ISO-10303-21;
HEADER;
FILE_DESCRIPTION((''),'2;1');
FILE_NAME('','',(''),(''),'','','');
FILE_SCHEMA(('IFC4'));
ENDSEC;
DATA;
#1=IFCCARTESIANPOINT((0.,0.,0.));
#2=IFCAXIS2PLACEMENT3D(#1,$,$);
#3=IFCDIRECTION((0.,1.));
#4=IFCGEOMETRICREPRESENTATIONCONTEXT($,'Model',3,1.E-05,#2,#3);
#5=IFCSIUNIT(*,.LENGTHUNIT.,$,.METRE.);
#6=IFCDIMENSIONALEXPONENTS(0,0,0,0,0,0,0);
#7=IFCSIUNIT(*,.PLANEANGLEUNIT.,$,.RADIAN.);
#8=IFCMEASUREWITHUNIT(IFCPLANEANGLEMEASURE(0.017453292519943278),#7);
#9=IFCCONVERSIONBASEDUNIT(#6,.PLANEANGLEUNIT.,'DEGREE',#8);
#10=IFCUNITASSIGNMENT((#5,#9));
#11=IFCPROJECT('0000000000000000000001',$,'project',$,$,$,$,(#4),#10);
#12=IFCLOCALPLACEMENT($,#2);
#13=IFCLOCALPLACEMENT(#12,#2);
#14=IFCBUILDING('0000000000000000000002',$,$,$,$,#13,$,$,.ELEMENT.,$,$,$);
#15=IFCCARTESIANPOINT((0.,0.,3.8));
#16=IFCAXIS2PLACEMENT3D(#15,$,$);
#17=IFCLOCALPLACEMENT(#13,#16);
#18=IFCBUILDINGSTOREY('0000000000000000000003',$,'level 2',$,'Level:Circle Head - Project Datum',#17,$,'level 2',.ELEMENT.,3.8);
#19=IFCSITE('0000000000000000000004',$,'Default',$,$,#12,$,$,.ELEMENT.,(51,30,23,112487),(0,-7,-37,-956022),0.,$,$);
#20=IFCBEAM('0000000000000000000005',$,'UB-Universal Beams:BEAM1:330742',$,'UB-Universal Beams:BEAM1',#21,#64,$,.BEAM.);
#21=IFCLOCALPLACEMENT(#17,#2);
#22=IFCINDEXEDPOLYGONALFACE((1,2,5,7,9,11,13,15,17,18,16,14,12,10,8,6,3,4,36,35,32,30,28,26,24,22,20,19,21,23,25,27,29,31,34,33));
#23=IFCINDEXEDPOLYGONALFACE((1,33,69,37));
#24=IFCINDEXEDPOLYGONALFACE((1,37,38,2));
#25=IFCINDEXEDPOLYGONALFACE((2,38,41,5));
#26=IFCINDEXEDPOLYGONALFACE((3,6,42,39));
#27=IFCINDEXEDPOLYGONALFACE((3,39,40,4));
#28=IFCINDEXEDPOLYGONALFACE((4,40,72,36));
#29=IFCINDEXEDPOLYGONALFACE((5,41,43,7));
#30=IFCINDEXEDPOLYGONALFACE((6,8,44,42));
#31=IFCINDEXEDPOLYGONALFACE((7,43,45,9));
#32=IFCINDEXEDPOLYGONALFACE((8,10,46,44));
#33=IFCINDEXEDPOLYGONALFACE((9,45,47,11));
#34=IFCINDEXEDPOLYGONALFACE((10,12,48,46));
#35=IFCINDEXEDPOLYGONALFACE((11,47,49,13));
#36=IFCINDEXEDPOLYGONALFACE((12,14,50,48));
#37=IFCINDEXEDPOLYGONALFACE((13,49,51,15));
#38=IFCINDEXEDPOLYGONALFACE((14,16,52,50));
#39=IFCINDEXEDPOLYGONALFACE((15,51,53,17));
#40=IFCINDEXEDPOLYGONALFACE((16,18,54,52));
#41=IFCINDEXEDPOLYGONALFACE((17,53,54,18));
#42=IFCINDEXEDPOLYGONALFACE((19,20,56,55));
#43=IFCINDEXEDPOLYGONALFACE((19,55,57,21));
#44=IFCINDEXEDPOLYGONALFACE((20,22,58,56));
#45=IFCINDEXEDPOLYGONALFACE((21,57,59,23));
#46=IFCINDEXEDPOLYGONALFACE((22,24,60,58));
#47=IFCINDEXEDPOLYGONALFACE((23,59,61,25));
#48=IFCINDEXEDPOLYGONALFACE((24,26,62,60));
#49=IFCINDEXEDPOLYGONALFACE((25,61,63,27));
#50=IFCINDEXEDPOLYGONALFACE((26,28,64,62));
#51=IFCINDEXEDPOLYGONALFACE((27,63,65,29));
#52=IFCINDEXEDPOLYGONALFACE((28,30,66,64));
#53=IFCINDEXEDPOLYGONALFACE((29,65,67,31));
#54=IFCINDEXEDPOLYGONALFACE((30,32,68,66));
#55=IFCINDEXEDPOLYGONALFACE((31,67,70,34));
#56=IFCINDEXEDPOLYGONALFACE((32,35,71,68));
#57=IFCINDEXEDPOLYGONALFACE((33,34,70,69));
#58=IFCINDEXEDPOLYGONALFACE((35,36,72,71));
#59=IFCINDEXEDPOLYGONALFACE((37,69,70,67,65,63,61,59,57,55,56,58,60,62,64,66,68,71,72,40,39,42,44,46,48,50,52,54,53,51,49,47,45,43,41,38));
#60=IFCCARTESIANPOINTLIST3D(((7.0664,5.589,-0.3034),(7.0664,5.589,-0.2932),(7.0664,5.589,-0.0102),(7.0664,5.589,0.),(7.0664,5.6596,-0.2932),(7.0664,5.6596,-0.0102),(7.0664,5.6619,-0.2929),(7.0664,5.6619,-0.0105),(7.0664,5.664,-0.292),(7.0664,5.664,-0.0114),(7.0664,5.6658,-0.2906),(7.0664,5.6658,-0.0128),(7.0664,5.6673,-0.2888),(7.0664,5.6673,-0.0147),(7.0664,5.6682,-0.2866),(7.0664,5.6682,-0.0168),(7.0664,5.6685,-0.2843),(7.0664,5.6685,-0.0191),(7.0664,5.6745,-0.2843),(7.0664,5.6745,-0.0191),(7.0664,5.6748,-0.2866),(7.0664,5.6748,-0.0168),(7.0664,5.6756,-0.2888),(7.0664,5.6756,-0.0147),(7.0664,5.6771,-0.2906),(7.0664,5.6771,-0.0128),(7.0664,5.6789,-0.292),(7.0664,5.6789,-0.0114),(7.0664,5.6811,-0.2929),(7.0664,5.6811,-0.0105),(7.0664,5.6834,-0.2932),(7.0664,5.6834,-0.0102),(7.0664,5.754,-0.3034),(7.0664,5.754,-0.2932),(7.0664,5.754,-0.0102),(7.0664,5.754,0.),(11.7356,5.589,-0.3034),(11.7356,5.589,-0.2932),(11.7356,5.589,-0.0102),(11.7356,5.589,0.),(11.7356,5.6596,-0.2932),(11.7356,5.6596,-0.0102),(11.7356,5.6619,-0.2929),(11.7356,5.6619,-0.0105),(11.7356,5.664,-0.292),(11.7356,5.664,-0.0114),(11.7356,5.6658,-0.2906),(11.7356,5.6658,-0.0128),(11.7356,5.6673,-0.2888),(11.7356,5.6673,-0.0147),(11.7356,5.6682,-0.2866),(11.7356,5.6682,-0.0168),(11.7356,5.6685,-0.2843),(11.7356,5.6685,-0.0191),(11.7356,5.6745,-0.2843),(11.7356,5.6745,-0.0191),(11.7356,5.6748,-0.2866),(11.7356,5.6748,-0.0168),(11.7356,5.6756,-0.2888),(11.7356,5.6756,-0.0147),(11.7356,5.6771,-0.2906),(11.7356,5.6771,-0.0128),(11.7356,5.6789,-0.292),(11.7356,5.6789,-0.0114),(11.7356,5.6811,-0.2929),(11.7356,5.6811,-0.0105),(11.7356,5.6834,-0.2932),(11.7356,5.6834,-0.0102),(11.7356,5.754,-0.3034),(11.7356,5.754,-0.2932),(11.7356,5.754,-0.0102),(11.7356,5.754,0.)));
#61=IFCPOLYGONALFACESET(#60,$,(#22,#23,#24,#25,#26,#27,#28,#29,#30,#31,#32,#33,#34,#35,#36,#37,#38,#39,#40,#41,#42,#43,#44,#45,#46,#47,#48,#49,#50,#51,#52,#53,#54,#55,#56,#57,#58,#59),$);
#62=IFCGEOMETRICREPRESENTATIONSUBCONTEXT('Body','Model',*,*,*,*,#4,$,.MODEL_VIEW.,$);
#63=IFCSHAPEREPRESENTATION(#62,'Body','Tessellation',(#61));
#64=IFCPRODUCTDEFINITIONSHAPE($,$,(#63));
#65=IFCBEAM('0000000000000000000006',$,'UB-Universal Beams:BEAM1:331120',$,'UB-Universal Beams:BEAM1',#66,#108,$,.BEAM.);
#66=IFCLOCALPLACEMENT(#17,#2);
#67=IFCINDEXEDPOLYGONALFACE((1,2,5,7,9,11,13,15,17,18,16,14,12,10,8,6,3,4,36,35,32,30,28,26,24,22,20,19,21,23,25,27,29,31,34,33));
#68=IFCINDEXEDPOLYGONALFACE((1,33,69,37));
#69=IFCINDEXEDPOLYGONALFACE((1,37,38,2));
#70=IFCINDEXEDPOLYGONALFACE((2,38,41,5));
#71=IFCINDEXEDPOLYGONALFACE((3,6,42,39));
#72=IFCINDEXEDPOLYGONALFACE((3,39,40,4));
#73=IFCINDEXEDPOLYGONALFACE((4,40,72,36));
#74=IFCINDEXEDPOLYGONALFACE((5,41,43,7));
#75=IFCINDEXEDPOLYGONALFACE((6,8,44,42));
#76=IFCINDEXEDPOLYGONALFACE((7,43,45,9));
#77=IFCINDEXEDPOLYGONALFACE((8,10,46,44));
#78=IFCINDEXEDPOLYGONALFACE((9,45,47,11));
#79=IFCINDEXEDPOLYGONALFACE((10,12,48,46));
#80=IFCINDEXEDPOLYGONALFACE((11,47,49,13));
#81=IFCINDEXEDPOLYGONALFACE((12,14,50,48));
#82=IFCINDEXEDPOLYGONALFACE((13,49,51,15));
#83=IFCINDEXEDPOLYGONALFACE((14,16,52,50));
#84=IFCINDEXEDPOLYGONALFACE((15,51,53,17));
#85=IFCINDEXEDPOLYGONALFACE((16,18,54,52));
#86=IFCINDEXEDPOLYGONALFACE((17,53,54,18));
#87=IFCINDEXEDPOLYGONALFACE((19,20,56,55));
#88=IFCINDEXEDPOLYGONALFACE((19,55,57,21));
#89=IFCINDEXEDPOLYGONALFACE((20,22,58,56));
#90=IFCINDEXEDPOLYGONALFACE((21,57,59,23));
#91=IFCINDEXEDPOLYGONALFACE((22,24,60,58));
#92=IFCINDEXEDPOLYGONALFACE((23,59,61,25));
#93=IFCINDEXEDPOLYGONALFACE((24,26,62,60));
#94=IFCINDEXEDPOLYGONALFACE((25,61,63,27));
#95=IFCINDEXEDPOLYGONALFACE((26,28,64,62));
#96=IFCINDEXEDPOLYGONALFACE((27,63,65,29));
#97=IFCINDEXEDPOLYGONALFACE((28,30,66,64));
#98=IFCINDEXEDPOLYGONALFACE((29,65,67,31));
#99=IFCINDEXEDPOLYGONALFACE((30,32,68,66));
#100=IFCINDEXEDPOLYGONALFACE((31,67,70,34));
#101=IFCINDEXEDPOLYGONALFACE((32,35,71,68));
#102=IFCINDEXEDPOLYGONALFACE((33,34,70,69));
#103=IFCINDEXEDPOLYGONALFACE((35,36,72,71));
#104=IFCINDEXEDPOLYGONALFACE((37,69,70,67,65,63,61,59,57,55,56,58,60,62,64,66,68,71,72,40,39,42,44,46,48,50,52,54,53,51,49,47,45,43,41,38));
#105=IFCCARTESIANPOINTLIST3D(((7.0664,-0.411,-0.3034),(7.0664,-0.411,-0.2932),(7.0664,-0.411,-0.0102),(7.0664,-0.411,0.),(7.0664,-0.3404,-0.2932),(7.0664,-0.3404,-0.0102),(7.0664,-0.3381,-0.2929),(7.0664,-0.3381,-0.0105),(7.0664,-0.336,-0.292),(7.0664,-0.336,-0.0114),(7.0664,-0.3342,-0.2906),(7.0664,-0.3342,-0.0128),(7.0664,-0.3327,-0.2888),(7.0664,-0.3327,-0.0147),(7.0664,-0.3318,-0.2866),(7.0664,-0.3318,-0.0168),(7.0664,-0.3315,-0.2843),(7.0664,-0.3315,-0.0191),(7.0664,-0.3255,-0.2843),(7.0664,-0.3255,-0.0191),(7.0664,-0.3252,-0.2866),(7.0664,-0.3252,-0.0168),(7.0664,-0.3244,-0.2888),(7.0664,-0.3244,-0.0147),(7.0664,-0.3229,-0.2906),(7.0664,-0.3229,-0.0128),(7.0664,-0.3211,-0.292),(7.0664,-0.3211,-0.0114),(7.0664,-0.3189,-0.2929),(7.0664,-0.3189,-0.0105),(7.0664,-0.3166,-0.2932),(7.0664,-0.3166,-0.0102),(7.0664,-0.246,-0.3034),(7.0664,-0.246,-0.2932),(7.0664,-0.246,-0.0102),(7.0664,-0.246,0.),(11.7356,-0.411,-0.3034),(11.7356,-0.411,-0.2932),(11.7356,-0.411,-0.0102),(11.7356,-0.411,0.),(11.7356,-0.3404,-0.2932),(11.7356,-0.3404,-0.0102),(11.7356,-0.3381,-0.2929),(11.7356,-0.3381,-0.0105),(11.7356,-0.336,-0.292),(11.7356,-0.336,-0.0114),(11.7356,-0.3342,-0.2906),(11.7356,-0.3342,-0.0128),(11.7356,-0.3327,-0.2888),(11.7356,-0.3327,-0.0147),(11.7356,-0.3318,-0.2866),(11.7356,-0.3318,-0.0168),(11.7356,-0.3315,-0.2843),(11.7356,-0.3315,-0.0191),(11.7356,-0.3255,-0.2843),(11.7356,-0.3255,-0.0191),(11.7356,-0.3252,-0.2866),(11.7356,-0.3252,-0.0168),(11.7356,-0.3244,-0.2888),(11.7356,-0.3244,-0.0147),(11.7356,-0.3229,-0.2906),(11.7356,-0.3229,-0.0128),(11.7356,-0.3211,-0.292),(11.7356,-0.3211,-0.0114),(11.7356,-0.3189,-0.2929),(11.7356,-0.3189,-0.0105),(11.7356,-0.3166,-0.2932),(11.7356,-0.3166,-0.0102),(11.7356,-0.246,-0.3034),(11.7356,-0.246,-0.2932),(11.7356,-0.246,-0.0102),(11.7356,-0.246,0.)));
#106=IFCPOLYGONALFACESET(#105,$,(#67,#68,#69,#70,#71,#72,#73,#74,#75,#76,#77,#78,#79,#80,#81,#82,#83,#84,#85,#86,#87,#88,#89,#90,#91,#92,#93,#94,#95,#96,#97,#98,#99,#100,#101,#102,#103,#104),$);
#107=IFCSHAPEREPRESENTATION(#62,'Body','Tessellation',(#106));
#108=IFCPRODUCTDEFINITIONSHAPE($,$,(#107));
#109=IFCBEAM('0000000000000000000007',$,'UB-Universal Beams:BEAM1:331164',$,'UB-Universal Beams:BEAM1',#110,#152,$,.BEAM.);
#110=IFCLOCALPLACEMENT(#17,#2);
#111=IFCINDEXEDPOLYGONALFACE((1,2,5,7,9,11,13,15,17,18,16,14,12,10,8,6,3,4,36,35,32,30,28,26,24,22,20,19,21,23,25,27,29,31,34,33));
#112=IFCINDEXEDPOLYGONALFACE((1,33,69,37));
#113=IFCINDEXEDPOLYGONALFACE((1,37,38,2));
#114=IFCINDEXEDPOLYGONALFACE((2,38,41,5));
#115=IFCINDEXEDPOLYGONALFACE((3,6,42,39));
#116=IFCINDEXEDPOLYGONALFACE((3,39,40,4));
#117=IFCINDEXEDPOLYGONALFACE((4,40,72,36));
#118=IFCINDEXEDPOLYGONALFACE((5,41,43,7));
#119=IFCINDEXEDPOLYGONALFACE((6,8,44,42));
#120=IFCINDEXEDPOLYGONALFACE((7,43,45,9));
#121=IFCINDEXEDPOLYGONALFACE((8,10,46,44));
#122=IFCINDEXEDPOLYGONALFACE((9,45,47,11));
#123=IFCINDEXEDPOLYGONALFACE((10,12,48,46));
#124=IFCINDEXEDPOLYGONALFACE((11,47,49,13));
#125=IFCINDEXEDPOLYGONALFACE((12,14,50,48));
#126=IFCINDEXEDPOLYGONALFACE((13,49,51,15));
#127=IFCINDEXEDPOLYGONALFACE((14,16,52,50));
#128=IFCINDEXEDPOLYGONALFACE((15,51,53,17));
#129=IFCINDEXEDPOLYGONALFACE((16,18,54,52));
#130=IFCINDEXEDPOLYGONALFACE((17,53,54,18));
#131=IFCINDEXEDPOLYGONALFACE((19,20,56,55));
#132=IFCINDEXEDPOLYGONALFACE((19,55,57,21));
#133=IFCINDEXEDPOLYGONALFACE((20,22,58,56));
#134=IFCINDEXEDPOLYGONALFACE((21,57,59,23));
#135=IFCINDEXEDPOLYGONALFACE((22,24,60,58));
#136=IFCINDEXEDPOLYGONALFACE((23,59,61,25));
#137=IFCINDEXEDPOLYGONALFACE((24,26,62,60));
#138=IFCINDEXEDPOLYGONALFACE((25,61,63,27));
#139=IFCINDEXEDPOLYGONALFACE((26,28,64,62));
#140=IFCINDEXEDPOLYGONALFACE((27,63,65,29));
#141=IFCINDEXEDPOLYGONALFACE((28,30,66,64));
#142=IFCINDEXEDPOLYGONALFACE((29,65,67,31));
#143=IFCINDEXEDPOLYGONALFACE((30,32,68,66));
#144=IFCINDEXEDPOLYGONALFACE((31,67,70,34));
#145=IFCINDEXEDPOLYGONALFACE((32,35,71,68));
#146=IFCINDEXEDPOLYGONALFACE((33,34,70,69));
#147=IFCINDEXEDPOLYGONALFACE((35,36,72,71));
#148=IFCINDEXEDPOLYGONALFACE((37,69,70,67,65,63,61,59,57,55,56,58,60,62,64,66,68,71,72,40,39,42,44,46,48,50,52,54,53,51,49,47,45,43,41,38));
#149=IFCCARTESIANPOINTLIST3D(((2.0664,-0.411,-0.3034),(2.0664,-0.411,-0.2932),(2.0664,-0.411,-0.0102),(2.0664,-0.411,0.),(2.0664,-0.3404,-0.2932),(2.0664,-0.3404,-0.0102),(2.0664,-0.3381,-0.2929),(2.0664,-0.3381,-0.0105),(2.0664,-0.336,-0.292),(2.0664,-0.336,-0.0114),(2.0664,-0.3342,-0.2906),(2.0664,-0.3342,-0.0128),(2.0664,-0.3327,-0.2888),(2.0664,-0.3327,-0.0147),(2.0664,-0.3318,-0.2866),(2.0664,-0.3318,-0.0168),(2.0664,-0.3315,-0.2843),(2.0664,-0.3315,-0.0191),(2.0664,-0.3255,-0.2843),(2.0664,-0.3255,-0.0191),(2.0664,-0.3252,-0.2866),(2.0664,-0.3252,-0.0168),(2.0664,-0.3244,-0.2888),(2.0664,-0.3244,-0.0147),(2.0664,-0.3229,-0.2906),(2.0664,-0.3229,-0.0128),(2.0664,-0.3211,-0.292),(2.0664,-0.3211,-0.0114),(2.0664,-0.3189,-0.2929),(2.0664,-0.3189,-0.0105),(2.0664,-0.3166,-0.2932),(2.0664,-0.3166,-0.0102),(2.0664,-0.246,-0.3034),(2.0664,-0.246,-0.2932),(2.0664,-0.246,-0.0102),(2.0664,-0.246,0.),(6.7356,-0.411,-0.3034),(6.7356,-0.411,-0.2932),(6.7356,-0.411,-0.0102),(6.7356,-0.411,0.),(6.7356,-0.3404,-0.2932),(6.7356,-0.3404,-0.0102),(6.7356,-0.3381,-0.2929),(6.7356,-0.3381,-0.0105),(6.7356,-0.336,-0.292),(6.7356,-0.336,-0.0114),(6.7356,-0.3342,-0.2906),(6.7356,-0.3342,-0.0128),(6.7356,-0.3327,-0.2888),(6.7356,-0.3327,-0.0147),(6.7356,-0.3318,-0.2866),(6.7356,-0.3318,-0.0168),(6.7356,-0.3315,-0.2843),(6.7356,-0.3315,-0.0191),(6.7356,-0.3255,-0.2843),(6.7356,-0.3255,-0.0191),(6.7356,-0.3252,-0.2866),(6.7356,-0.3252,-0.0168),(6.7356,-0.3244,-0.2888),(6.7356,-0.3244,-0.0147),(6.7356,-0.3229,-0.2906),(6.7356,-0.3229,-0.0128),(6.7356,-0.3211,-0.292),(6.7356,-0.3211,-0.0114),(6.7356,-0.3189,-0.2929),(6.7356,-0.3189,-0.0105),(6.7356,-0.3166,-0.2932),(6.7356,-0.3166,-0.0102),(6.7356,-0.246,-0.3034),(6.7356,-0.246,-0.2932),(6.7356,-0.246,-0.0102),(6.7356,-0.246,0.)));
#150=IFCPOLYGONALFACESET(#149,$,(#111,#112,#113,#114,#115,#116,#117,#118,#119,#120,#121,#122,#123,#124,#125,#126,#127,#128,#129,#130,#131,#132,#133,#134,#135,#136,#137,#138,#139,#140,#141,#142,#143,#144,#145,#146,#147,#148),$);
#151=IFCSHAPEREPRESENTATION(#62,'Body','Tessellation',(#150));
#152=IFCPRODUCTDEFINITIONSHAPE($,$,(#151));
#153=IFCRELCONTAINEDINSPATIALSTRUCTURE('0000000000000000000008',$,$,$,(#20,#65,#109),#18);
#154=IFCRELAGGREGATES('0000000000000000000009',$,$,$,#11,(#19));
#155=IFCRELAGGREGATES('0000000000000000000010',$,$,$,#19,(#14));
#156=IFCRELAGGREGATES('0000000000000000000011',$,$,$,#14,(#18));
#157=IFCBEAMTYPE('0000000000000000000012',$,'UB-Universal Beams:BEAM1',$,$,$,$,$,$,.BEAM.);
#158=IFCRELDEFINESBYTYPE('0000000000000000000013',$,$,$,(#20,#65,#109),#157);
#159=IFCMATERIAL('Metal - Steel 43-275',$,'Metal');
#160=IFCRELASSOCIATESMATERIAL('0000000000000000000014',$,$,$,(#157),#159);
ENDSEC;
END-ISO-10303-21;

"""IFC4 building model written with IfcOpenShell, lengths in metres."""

from ifc_helpers import new_model, entity, si_unit, converted_unit, direction, frame, frame_2d, origin, place, context, subcontext, project, spatial, polyline, circle_curve, parameter, trimmed, segment, composite_curve, outline, extrude, source, transform, mapped, material, material_profile, profile_set, type_object, type_shapes, element, save


model = new_model("IFC4")

# Units and contexts
model_context = context("Model", 3, precision=1e-05, world=origin(), true_north=direction((0.0, 1.0)))
body_context = subcontext(model_context, "Body", "Model", "MODEL_VIEW")
ifc_project = project(units=[si_unit("LENGTHUNIT", "METRE"), converted_unit("PLANEANGLEUNIT", "DEGREE", entity("IfcPlaneAngleMeasure", 0.017453292519943278), si_unit("PLANEANGLEUNIT", "RADIAN"), dimensions=[0, 0, 0, 0, 0, 0, 0])], contexts=[model_context])

# Site, building, storey
site_placement = place(None, origin())
site = spatial("IfcSite", under=ifc_project, at=site_placement, Name="Default", CompositionType="ELEMENT", RefLatitude=(51, 30, 23, 112487), RefLongitude=(0, -7, -37, -956022), RefElevation=0.0)
building_placement = place(site_placement, origin())
building = spatial("IfcBuilding", under=site, at=building_placement, CompositionType="ELEMENT")
storey_placement = place(building_placement, frame((0.0, 0.0, 3.8)))
storey = spatial("IfcBuildingStorey", under=building, at=storey_placement, Name="level 2", ObjectType="Level:Circle Head - Project Datum", LongName="level 2", CompositionType="ELEMENT", Elevation=3.8)

# Shared definitions
ifc_material_1 = material(Name="Metal - Steel 43-275", Category="Metal")

# Beams
ifc_material_profile_1 = material_profile(ifc_material_1, outline(composite_curve([segment(polyline([(-0.0825, -0.1415), (-0.0825, -0.1517)]), True, "CONTINUOUS"), segment(polyline([(-0.0825, -0.1517), (0.0825, -0.1517)]), True, "CONTINUOUS"), segment(polyline([(0.0825, -0.1517), (0.0825, -0.1415)]), True, "CONTINUOUS"), segment(polyline([(0.0825, -0.1415), (0.0119, -0.1415)]), True, "CONTINUOUS"), segment(trimmed(circle_curve(frame_2d((0.0119, -0.1326), x_axis=(1.0, 0.0)), 0.0089), [parameter(180.0)], [parameter(270.0)], True, "PARAMETER"), False, "CONTINUOUS"), segment(polyline([(0.003, -0.1326), (0.003, 0.1326)]), True, "CONTINUOUS"), segment(trimmed(circle_curve(frame_2d((0.0119, 0.1326), x_axis=(1.0, 0.0)), 0.0089), [parameter(90.0)], [parameter(180.0)], True, "PARAMETER"), False, "CONTINUOUS"), segment(polyline([(0.0119, 0.1415), (0.0825, 0.1415)]), True, "CONTINUOUS"), segment(polyline([(0.0825, 0.1415), (0.0825, 0.1517)]), True, "CONTINUOUS"), segment(polyline([(0.0825, 0.1517), (-0.0825, 0.1517)]), True, "CONTINUOUS"), segment(polyline([(-0.0825, 0.1517), (-0.0825, 0.1415)]), True, "CONTINUOUS"), segment(polyline([(-0.0825, 0.1415), (-0.0119, 0.1415)]), True, "CONTINUOUS"), segment(trimmed(circle_curve(frame_2d((-0.0119, 0.1326), x_axis=(1.0, 0.0)), 0.0089), [parameter(360.0)], [parameter(90.0)], True, "PARAMETER"), False, "CONTINUOUS"), segment(polyline([(-0.003, 0.1326), (-0.003, -0.1326)]), True, "CONTINUOUS"), segment(trimmed(circle_curve(frame_2d((-0.0119, -0.1326), x_axis=(1.0, 0.0)), 0.0089), [parameter(270.0)], [parameter(360.0)], True, "PARAMETER"), False, "CONTINUOUS"), segment(polyline([(-0.0119, -0.1415), (-0.0825, -0.1415)]), True, "CONTINUOUS")], self_intersect=False)), Name="BEAM1")
ifc_profile_set_1 = profile_set([ifc_material_profile_1], Name="BEAM1")
beam_type_1 = type_object("IfcBeamType", Name="UB-Universal Beams:BEAM1", PredefinedType="BEAM", material=ifc_profile_set_1)
shared_shape_1 = source(origin(), body_context, "Body", "SweptSolid", [
    extrude(outline(composite_curve([segment(polyline([(-0.0825, -0.1415), (-0.0825, -0.1517)]), True, "CONTINUOUS"), segment(polyline([(-0.0825, -0.1517), (0.0825, -0.1517)]), True, "CONTINUOUS"), segment(polyline([(0.0825, -0.1517), (0.0825, -0.1415)]), True, "CONTINUOUS"), segment(polyline([(0.0825, -0.1415), (0.0119, -0.1415)]), True, "CONTINUOUS"), segment(trimmed(circle_curve(frame_2d((0.0119, -0.1326), x_axis=(1.0, 0.0)), 0.0089), [parameter(180.0)], [parameter(270.0)], True, "PARAMETER"), False, "CONTINUOUS"), segment(polyline([(0.003, -0.1326), (0.003, 0.1326)]), True, "CONTINUOUS"), segment(trimmed(circle_curve(frame_2d((0.0119, 0.1326), x_axis=(1.0, 0.0)), 0.0089), [parameter(90.0)], [parameter(180.0)], True, "PARAMETER"), False, "CONTINUOUS"), segment(polyline([(0.0119, 0.1415), (0.0825, 0.1415)]), True, "CONTINUOUS"), segment(polyline([(0.0825, 0.1415), (0.0825, 0.1517)]), True, "CONTINUOUS"), segment(polyline([(0.0825, 0.1517), (-0.0825, 0.1517)]), True, "CONTINUOUS"), segment(polyline([(-0.0825, 0.1517), (-0.0825, 0.1415)]), True, "CONTINUOUS"), segment(polyline([(-0.0825, 0.1415), (-0.0119, 0.1415)]), True, "CONTINUOUS"), segment(trimmed(circle_curve(frame_2d((-0.0119, 0.1326), x_axis=(1.0, 0.0)), 0.0089), [parameter(360.0)], [parameter(90.0)], True, "PARAMETER"), False, "CONTINUOUS"), segment(polyline([(-0.003, 0.1326), (-0.003, -0.1326)]), True, "CONTINUOUS"), segment(trimmed(circle_curve(frame_2d((-0.0119, -0.1326), x_axis=(1.0, 0.0)), 0.0089), [parameter(270.0)], [parameter(360.0)], True, "PARAMETER"), False, "CONTINUOUS"), segment(polyline([(-0.0119, -0.1415), (-0.0825, -0.1415)]), True, "CONTINUOUS")], self_intersect=False)), frame((-2.3346, 0.0, 0.0), z_axis=(-1.0, 0.0, 0.0), x_axis=(0.0, -1.0, 0.0)), (0.0, 0.0, -1.0), 4.6692),
])
type_shapes(beam_type_1, [shared_shape_1])
for number, where, name in (
    (1, (9.401, 5.6715, -0.1517), "UB-Universal Beams:BEAM1:330742"),
    (2, (9.401, -0.3285, -0.1517), "UB-Universal Beams:BEAM1:331120"),
    (3, (4.401, -0.3285, -0.1517), "UB-Universal Beams:BEAM1:331164"),
):
    element("IfcBeam", number, at=place(storey_placement, frame(where)), inside=storey, type_object=beam_type_1, Name=name, ObjectType="UB-Universal Beams:BEAM1", PredefinedType="BEAM", context=body_context, shape_type="MappedRepresentation", body=[
        mapped(shared_shape_1, transform((0.0, 0.0, 0.0), scale=1.0)),
    ])

save(model, "model.ifc")
